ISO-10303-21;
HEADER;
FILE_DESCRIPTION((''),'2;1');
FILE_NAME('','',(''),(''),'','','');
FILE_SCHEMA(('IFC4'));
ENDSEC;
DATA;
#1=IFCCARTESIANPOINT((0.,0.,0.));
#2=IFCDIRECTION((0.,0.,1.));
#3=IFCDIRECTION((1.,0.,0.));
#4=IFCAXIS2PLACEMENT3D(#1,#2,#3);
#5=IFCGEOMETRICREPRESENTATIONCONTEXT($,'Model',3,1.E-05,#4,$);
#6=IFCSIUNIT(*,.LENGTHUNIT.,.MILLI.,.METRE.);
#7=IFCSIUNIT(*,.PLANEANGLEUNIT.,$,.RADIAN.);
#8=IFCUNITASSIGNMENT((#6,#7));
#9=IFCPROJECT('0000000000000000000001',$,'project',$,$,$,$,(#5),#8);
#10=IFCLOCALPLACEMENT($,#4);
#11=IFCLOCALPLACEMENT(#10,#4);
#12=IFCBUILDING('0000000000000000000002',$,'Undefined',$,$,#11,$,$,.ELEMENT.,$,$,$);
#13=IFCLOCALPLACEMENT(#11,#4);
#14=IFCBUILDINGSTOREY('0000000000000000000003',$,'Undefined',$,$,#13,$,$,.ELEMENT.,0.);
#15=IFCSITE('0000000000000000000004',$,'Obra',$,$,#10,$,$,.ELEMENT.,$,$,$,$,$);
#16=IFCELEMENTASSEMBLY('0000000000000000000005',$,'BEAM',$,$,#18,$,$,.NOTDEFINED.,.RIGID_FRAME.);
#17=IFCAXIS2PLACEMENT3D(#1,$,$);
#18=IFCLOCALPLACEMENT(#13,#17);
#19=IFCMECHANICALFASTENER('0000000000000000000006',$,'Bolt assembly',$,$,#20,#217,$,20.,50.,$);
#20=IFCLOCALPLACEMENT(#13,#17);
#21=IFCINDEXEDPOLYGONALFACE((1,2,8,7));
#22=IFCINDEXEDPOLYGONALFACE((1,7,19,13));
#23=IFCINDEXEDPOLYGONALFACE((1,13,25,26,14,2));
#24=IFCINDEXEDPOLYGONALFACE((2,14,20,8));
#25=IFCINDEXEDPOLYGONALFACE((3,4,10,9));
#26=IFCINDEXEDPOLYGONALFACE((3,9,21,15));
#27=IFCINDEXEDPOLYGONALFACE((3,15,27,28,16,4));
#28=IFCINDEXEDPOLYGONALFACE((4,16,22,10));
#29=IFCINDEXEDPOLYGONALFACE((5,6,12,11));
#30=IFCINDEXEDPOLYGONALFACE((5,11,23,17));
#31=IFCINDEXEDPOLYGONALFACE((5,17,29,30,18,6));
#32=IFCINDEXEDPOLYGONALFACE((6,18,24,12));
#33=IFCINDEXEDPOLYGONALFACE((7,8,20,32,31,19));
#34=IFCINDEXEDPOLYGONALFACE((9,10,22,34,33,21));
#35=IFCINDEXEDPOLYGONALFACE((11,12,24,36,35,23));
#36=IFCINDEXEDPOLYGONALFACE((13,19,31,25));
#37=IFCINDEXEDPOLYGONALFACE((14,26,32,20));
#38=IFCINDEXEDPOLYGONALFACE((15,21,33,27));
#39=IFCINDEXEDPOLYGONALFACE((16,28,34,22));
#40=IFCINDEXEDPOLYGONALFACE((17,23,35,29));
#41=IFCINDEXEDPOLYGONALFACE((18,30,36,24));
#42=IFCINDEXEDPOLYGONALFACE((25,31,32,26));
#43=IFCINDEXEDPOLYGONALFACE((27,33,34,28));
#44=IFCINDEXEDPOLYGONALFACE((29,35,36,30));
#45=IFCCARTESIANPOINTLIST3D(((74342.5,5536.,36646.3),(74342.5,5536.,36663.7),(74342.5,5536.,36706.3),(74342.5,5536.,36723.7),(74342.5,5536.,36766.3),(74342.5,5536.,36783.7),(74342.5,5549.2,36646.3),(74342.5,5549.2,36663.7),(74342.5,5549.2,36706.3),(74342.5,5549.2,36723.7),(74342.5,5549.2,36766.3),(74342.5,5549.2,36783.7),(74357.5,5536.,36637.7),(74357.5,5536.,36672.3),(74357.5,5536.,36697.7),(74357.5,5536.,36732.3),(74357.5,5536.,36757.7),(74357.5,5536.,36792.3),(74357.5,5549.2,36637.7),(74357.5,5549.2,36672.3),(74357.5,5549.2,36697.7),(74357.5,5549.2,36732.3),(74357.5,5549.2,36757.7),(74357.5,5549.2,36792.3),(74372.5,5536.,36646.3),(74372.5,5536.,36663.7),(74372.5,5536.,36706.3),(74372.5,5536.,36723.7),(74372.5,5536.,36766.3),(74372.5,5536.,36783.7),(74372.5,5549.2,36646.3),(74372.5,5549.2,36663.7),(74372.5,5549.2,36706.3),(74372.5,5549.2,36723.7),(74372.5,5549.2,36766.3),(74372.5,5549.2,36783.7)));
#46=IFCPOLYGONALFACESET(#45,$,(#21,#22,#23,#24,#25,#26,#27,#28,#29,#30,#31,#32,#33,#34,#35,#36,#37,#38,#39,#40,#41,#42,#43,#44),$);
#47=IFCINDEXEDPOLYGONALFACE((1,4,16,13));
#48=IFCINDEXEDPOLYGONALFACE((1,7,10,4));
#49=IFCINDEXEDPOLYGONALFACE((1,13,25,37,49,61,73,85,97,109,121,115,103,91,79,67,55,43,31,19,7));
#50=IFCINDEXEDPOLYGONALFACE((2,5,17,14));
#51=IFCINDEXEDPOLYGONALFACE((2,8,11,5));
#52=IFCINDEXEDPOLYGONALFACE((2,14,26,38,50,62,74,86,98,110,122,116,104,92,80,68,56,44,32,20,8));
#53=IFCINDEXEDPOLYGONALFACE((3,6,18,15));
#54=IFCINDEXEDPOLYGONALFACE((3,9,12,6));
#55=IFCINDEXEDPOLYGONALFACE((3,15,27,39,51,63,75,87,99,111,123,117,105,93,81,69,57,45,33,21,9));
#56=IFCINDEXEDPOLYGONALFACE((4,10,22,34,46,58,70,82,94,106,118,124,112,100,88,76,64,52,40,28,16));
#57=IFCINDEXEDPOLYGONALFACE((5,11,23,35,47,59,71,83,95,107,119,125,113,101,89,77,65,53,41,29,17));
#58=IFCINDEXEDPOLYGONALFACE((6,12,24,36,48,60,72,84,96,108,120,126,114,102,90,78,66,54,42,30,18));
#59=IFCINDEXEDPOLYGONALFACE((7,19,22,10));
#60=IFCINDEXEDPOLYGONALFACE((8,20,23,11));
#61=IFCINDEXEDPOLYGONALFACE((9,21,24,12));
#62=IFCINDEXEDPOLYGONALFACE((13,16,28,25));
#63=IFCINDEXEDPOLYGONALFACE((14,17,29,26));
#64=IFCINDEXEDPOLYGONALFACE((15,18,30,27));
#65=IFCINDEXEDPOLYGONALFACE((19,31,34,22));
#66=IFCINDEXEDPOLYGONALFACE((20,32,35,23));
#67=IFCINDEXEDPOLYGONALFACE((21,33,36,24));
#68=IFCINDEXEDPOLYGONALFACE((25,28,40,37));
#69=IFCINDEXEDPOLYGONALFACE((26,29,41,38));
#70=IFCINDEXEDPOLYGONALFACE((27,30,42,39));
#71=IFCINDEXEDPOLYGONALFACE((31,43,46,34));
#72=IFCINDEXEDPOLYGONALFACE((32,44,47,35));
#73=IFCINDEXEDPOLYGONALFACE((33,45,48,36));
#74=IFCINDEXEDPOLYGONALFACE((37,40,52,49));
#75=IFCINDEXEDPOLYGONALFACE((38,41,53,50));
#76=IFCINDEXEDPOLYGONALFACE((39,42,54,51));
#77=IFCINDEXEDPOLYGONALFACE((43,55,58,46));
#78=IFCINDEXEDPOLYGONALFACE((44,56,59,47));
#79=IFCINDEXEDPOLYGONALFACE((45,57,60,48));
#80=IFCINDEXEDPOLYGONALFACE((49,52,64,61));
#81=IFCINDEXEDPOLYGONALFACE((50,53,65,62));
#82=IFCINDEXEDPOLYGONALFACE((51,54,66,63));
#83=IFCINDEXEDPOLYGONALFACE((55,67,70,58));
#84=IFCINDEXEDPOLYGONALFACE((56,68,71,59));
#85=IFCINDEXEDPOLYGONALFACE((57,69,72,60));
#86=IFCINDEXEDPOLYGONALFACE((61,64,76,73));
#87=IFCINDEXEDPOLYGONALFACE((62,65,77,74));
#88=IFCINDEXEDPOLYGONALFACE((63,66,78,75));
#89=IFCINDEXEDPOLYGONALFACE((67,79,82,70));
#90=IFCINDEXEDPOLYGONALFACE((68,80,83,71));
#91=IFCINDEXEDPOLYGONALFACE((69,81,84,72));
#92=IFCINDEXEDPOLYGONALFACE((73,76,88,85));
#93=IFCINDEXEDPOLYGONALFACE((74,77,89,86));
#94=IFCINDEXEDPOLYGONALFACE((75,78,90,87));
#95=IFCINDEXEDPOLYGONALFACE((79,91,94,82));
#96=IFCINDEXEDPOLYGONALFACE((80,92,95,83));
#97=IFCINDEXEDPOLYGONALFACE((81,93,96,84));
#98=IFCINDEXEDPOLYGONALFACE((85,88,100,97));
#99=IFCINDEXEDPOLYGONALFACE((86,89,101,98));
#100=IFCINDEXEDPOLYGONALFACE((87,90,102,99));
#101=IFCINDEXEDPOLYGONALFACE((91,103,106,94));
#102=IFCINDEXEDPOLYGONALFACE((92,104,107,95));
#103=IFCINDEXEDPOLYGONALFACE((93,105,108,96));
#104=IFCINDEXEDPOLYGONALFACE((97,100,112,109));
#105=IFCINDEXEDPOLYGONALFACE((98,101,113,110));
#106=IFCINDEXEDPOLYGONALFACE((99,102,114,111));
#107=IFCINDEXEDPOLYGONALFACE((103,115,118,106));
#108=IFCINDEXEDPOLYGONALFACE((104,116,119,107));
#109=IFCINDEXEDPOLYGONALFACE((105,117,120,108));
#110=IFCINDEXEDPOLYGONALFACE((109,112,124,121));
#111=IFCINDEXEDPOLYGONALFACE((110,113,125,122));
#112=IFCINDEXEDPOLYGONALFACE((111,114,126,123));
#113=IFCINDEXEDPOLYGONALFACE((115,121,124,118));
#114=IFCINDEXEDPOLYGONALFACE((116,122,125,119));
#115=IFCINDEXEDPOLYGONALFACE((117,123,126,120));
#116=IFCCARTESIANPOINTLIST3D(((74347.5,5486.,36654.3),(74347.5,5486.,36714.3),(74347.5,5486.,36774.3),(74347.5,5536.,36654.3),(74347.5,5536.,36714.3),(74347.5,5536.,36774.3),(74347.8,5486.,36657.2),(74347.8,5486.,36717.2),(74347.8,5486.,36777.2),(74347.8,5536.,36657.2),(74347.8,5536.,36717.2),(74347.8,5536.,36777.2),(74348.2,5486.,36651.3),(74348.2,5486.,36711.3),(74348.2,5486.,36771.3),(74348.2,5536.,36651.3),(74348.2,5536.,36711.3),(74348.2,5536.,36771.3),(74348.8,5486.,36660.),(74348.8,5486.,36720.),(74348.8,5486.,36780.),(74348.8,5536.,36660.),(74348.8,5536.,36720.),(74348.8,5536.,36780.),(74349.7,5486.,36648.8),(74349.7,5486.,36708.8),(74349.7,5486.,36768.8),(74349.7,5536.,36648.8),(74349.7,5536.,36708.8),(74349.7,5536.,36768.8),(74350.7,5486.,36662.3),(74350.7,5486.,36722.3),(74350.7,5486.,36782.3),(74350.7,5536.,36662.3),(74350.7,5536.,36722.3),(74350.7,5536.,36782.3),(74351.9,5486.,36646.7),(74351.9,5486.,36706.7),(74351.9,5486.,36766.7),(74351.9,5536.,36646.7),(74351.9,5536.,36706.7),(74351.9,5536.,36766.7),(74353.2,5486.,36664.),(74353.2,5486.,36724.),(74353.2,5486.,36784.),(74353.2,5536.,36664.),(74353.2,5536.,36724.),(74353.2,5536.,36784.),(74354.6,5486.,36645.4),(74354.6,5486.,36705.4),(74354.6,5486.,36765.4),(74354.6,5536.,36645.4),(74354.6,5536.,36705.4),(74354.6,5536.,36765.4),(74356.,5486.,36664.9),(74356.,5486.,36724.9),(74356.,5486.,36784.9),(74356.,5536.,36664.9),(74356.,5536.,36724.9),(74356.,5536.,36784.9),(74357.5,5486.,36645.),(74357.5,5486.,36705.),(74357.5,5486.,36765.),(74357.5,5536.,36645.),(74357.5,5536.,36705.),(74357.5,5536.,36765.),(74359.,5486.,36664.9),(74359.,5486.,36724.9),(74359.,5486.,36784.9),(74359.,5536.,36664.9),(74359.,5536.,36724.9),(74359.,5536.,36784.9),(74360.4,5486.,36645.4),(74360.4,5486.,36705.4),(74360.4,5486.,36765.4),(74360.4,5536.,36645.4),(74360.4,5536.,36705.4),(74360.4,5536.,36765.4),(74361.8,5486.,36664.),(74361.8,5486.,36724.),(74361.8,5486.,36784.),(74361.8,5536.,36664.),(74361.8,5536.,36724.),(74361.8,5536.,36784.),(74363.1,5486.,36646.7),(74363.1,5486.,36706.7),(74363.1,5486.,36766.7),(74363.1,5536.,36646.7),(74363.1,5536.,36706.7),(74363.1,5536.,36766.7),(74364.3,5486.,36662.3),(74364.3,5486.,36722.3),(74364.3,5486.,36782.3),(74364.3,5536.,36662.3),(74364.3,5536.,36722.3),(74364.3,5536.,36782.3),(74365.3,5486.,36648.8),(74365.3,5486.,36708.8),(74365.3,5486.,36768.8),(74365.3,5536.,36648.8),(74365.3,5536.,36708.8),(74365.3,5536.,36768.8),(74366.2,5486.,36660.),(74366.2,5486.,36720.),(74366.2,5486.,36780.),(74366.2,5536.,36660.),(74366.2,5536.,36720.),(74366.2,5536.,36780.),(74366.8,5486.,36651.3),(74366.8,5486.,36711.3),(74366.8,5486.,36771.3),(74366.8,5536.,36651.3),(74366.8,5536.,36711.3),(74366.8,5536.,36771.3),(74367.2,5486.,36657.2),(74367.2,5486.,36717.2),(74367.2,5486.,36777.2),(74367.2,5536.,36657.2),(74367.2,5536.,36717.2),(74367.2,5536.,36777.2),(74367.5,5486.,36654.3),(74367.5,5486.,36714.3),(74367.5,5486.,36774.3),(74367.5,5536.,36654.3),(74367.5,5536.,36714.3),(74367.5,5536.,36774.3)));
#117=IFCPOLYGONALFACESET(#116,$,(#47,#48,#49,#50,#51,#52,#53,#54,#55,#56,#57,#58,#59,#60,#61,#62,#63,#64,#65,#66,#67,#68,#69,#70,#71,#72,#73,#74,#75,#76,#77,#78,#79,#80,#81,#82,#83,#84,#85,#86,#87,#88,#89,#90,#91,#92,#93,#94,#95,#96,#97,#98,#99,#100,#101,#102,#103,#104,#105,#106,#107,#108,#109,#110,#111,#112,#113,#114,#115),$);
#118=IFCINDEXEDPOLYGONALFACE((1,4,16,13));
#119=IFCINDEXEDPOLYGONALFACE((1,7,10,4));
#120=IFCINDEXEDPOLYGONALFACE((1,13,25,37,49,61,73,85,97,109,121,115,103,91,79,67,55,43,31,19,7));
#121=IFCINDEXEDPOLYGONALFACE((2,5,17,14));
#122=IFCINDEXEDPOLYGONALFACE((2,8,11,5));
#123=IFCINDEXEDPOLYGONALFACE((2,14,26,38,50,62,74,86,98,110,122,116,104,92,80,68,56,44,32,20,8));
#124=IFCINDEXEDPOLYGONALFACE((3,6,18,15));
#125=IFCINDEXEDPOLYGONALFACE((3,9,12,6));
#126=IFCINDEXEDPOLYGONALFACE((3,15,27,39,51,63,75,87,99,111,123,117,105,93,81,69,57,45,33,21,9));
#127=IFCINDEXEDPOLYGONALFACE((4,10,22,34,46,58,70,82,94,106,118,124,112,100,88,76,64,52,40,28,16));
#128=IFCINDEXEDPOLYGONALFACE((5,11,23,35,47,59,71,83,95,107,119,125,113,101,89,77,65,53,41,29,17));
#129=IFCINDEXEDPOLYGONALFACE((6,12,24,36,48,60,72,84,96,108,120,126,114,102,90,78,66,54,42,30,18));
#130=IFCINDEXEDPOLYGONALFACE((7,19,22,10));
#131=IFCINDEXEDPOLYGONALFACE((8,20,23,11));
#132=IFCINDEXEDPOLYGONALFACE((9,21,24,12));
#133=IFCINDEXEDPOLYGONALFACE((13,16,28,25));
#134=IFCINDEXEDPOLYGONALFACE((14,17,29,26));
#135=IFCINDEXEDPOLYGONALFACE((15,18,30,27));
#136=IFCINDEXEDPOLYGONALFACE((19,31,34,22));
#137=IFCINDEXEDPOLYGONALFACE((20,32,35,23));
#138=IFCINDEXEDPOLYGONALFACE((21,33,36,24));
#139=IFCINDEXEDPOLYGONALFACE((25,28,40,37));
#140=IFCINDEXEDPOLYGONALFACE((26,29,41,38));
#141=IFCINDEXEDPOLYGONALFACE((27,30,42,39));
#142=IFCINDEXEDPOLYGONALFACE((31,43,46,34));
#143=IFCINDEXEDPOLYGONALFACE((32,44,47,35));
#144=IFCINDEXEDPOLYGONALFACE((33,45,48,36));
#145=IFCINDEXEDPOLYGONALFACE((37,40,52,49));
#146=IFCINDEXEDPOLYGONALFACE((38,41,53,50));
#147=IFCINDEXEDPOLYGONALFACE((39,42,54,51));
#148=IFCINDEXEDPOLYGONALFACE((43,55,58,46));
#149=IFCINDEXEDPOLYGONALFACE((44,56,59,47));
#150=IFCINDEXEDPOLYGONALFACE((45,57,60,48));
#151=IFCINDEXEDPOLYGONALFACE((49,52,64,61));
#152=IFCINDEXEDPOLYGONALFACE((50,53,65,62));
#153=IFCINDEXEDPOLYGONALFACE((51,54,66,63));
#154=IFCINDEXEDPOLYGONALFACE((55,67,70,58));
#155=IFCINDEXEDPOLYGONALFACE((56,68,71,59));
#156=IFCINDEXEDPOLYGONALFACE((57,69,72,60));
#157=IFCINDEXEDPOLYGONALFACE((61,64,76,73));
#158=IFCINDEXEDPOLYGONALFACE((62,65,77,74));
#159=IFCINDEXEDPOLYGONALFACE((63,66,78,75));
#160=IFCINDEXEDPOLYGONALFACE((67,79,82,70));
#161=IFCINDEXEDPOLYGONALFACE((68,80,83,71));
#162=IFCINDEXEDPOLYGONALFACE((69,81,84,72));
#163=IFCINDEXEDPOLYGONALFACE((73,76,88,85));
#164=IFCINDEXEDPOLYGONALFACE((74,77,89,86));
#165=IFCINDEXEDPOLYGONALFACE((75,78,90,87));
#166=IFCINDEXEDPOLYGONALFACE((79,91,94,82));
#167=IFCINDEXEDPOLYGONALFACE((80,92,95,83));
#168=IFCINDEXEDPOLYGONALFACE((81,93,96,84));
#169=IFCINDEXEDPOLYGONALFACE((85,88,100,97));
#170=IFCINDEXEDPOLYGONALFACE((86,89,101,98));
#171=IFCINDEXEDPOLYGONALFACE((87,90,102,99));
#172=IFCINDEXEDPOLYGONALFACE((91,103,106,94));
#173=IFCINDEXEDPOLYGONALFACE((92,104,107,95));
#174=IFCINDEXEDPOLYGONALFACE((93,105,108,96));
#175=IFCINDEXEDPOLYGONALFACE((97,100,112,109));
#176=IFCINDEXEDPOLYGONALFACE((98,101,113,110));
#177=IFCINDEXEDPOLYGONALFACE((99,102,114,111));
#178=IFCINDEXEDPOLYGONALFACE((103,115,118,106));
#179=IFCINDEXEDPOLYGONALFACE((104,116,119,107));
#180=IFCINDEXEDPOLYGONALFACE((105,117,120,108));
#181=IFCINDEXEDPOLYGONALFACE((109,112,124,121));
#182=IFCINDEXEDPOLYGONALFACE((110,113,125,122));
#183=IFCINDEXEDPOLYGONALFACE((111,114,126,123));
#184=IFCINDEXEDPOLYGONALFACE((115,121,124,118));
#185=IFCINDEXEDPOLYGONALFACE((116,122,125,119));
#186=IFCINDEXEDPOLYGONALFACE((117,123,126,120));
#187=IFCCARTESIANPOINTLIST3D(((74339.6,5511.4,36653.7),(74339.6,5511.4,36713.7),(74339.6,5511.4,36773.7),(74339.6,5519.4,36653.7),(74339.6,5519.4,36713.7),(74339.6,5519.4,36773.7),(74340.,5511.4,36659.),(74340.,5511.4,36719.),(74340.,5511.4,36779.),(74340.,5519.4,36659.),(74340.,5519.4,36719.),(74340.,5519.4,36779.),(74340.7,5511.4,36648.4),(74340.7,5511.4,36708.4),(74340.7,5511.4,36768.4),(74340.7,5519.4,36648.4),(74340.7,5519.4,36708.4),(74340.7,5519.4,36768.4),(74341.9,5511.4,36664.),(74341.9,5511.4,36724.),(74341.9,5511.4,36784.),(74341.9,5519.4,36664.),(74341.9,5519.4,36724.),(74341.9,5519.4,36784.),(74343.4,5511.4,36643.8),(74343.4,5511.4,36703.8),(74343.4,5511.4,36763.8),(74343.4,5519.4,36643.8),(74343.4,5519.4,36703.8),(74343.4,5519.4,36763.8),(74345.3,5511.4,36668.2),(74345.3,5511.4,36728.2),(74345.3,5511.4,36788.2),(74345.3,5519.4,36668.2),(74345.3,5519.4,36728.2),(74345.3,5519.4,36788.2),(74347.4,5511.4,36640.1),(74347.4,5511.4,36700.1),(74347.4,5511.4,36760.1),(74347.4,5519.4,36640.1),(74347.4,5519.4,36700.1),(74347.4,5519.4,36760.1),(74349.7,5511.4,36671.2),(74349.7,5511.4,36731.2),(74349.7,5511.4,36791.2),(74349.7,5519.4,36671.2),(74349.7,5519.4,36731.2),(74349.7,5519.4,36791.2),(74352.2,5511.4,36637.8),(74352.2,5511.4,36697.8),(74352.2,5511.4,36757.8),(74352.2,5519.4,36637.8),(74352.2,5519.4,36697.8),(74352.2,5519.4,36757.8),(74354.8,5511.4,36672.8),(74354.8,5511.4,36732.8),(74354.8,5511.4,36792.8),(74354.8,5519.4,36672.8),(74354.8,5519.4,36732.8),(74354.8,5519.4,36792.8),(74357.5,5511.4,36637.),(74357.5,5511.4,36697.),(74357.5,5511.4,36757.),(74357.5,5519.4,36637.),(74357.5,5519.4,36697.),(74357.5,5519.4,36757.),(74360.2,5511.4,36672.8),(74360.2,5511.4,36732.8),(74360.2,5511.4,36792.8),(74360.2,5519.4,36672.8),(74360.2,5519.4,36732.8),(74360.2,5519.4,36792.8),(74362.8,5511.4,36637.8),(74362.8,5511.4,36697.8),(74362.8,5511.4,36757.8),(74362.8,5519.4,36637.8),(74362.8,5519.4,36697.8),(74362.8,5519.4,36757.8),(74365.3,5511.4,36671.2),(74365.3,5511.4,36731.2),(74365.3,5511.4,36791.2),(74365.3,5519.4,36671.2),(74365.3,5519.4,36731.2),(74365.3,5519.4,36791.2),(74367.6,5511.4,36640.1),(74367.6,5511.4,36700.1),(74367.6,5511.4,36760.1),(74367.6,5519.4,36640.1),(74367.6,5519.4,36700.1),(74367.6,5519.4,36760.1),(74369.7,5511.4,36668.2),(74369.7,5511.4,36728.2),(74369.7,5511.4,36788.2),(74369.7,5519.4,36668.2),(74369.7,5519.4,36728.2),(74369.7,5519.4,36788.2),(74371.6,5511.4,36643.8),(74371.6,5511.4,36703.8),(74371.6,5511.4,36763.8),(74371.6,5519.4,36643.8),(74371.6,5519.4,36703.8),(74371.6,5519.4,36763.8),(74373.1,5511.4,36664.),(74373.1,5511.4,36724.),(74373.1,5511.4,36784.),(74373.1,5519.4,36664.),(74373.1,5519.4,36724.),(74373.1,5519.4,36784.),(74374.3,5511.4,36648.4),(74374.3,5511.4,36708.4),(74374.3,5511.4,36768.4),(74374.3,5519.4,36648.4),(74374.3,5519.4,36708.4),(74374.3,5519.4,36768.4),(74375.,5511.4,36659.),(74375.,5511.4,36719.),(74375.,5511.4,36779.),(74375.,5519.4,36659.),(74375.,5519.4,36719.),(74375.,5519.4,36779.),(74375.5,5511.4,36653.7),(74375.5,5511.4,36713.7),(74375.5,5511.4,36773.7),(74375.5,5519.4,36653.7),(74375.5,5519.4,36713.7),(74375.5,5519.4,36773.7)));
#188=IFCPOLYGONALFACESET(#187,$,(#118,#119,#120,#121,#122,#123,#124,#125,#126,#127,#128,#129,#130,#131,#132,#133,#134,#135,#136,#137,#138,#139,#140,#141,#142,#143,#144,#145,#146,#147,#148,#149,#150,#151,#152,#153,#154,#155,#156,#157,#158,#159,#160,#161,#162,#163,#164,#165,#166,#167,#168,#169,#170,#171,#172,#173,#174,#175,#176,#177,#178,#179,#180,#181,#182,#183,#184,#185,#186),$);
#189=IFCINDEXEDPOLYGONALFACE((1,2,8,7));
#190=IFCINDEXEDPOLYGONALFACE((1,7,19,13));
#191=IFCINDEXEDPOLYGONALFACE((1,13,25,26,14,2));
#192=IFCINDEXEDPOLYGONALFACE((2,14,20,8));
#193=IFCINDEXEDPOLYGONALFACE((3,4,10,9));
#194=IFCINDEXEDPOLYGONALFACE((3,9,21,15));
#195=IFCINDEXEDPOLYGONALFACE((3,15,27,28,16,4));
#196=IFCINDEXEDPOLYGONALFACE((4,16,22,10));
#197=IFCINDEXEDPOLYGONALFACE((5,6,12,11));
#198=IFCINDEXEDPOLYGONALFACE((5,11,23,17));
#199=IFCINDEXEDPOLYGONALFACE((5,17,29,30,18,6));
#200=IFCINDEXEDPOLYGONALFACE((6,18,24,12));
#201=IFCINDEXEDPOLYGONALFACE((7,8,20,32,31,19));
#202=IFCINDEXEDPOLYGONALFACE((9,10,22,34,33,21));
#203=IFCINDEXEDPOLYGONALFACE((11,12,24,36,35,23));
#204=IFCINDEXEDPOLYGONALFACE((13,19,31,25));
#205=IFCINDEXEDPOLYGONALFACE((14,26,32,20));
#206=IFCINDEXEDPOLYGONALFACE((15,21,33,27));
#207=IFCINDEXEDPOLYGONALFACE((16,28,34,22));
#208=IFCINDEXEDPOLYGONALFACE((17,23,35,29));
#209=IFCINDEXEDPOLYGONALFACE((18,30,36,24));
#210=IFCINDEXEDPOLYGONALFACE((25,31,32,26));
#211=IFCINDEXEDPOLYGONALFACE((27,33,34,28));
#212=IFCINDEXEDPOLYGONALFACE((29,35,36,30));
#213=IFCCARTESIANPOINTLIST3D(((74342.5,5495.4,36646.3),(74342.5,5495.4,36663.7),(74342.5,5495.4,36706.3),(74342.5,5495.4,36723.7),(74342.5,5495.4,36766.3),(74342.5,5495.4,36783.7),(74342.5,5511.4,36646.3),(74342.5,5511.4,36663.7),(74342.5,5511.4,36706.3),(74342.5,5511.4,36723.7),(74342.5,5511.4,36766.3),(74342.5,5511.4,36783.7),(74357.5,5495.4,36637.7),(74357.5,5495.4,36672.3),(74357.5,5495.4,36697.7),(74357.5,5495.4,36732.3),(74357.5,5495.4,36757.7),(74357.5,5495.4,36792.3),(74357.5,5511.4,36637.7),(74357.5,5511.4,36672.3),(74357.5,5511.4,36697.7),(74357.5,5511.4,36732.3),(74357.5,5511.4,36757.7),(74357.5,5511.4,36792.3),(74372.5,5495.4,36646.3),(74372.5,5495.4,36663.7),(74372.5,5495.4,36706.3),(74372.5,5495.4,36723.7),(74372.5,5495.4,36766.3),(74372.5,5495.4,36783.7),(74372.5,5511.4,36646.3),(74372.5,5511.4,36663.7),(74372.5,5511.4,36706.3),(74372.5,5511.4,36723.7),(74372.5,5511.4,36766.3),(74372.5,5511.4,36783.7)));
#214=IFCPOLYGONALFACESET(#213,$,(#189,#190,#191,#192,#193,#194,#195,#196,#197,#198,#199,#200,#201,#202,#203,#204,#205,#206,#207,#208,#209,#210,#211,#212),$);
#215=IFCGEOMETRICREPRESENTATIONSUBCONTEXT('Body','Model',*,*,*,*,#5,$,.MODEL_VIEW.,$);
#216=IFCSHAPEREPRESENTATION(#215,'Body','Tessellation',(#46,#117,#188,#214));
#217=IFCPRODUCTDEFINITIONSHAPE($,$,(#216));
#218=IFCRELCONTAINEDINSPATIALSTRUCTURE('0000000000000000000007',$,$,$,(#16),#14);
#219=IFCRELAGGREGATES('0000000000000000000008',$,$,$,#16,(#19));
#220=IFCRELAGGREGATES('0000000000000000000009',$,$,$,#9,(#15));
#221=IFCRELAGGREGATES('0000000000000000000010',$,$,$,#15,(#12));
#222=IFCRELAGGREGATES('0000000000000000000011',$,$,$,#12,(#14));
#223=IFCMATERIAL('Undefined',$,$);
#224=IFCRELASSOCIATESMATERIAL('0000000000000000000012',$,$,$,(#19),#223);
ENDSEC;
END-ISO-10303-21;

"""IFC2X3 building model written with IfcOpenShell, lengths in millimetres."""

from ifc_helpers import new_model, si_unit, frame, origin_with_axes, origin_2d_with_axis, place, context, subcontext, project, spatial, polyline, circle, outline, extrude, source, transform, mapped, material, element, aggregate, save


model = new_model("IFC2X3")

# Units and contexts
model_context = context("Model", 3, precision=1e-05, world=origin_with_axes())
body_context = subcontext(model_context, "Body", "Model", "MODEL_VIEW")
ifc_project = project(units=[si_unit("LENGTHUNIT", "METRE", prefix="MILLI"), si_unit("PLANEANGLEUNIT", "RADIAN")], contexts=[model_context])

# Site, building, storey
site_placement = place(None, origin_with_axes())
site = spatial("IfcSite", under=ifc_project, at=site_placement, Name="Obra", CompositionType="ELEMENT")
building_placement = place(site_placement, origin_with_axes())
building = spatial("IfcBuilding", under=site, at=building_placement, Name="Undefined", CompositionType="ELEMENT")
storey_placement = place(building_placement, origin_with_axes())
storey = spatial("IfcBuildingStorey", under=building, at=storey_placement, Name="Undefined", CompositionType="ELEMENT", Elevation=0.0)

# Element assembly
assembly_1_placement = place(storey_placement, origin_with_axes())
assembly_1 = element("IfcElementAssembly", 1, at=assembly_1_placement, inside=storey, Name="BEAM", AssemblyPlace="NOTDEFINED", PredefinedType="RIGID_FRAME")

# Mechanical fastener
ifc_material_1 = material(Name="Undefined")
shared_shape_1 = source(origin_with_axes(), body_context, "Body", "SweptSolid", [
    extrude(outline(polyline([(17.3, 0.0), (8.7, 15.0), (-8.7, 15.0), (-17.3, 0.0), (-8.7, -15.0), (8.7, -15.0), (17.3, 0.0)])), frame((0.0, -26.5, 0.0), z_axis=(0.0, 1.0, 0.0), x_axis=(1.0, 0.0, 0.0)), (0.0, 0.0, 1.0), 13.2),
    extrude(circle(Radius=10.0, at=origin_2d_with_axis()), frame((0.0, -13.3, 0.0), z_axis=(0.0, 1.0, 0.0), x_axis=(1.0, 0.0, 0.0)), (0.0, 0.0, 1.0), 50.0),
    extrude(circle(Radius=18.0, at=origin_2d_with_axis()), frame((0.0, 3.3, 0.0), z_axis=(0.0, 1.0, 0.0), x_axis=(1.0, 0.0, 0.0)), (0.0, 0.0, 1.0), 8.0),
    extrude(outline(polyline([(17.3, 0.0), (8.7, 15.0), (-8.7, 15.0), (-17.3, 0.0), (-8.7, -15.0), (8.7, -15.0), (17.3, 0.0)])), frame((0.0, 11.3, 0.0), z_axis=(0.0, 1.0, 0.0), x_axis=(1.0, 0.0, 0.0)), (0.0, 0.0, 1.0), 16.0),
])
mechanical_fastener_1_placement = place(assembly_1_placement, frame((74407.5, 5522.7, 36815.0), z_axis=(-1.0, 0.0, 0.0), x_axis=(0.0, 0.0, -1.0)))
mechanical_fastener_1 = element("IfcMechanicalFastener", 2, at=mechanical_fastener_1_placement, material=ifc_material_1, Name="Bolt assembly", NominalDiameter=20.0, NominalLength=50.0, context=body_context, shape_type="MappedRepresentation", body=[
    mapped(shared_shape_1, transform((40.0, 0.0, 50.0))),
    mapped(shared_shape_1, transform((100.0, 0.0, 50.0))),
    mapped(shared_shape_1, transform((160.0, 0.0, 50.0))),
])

aggregate(assembly_1, [mechanical_fastener_1])

save(model, "model.ifc")
